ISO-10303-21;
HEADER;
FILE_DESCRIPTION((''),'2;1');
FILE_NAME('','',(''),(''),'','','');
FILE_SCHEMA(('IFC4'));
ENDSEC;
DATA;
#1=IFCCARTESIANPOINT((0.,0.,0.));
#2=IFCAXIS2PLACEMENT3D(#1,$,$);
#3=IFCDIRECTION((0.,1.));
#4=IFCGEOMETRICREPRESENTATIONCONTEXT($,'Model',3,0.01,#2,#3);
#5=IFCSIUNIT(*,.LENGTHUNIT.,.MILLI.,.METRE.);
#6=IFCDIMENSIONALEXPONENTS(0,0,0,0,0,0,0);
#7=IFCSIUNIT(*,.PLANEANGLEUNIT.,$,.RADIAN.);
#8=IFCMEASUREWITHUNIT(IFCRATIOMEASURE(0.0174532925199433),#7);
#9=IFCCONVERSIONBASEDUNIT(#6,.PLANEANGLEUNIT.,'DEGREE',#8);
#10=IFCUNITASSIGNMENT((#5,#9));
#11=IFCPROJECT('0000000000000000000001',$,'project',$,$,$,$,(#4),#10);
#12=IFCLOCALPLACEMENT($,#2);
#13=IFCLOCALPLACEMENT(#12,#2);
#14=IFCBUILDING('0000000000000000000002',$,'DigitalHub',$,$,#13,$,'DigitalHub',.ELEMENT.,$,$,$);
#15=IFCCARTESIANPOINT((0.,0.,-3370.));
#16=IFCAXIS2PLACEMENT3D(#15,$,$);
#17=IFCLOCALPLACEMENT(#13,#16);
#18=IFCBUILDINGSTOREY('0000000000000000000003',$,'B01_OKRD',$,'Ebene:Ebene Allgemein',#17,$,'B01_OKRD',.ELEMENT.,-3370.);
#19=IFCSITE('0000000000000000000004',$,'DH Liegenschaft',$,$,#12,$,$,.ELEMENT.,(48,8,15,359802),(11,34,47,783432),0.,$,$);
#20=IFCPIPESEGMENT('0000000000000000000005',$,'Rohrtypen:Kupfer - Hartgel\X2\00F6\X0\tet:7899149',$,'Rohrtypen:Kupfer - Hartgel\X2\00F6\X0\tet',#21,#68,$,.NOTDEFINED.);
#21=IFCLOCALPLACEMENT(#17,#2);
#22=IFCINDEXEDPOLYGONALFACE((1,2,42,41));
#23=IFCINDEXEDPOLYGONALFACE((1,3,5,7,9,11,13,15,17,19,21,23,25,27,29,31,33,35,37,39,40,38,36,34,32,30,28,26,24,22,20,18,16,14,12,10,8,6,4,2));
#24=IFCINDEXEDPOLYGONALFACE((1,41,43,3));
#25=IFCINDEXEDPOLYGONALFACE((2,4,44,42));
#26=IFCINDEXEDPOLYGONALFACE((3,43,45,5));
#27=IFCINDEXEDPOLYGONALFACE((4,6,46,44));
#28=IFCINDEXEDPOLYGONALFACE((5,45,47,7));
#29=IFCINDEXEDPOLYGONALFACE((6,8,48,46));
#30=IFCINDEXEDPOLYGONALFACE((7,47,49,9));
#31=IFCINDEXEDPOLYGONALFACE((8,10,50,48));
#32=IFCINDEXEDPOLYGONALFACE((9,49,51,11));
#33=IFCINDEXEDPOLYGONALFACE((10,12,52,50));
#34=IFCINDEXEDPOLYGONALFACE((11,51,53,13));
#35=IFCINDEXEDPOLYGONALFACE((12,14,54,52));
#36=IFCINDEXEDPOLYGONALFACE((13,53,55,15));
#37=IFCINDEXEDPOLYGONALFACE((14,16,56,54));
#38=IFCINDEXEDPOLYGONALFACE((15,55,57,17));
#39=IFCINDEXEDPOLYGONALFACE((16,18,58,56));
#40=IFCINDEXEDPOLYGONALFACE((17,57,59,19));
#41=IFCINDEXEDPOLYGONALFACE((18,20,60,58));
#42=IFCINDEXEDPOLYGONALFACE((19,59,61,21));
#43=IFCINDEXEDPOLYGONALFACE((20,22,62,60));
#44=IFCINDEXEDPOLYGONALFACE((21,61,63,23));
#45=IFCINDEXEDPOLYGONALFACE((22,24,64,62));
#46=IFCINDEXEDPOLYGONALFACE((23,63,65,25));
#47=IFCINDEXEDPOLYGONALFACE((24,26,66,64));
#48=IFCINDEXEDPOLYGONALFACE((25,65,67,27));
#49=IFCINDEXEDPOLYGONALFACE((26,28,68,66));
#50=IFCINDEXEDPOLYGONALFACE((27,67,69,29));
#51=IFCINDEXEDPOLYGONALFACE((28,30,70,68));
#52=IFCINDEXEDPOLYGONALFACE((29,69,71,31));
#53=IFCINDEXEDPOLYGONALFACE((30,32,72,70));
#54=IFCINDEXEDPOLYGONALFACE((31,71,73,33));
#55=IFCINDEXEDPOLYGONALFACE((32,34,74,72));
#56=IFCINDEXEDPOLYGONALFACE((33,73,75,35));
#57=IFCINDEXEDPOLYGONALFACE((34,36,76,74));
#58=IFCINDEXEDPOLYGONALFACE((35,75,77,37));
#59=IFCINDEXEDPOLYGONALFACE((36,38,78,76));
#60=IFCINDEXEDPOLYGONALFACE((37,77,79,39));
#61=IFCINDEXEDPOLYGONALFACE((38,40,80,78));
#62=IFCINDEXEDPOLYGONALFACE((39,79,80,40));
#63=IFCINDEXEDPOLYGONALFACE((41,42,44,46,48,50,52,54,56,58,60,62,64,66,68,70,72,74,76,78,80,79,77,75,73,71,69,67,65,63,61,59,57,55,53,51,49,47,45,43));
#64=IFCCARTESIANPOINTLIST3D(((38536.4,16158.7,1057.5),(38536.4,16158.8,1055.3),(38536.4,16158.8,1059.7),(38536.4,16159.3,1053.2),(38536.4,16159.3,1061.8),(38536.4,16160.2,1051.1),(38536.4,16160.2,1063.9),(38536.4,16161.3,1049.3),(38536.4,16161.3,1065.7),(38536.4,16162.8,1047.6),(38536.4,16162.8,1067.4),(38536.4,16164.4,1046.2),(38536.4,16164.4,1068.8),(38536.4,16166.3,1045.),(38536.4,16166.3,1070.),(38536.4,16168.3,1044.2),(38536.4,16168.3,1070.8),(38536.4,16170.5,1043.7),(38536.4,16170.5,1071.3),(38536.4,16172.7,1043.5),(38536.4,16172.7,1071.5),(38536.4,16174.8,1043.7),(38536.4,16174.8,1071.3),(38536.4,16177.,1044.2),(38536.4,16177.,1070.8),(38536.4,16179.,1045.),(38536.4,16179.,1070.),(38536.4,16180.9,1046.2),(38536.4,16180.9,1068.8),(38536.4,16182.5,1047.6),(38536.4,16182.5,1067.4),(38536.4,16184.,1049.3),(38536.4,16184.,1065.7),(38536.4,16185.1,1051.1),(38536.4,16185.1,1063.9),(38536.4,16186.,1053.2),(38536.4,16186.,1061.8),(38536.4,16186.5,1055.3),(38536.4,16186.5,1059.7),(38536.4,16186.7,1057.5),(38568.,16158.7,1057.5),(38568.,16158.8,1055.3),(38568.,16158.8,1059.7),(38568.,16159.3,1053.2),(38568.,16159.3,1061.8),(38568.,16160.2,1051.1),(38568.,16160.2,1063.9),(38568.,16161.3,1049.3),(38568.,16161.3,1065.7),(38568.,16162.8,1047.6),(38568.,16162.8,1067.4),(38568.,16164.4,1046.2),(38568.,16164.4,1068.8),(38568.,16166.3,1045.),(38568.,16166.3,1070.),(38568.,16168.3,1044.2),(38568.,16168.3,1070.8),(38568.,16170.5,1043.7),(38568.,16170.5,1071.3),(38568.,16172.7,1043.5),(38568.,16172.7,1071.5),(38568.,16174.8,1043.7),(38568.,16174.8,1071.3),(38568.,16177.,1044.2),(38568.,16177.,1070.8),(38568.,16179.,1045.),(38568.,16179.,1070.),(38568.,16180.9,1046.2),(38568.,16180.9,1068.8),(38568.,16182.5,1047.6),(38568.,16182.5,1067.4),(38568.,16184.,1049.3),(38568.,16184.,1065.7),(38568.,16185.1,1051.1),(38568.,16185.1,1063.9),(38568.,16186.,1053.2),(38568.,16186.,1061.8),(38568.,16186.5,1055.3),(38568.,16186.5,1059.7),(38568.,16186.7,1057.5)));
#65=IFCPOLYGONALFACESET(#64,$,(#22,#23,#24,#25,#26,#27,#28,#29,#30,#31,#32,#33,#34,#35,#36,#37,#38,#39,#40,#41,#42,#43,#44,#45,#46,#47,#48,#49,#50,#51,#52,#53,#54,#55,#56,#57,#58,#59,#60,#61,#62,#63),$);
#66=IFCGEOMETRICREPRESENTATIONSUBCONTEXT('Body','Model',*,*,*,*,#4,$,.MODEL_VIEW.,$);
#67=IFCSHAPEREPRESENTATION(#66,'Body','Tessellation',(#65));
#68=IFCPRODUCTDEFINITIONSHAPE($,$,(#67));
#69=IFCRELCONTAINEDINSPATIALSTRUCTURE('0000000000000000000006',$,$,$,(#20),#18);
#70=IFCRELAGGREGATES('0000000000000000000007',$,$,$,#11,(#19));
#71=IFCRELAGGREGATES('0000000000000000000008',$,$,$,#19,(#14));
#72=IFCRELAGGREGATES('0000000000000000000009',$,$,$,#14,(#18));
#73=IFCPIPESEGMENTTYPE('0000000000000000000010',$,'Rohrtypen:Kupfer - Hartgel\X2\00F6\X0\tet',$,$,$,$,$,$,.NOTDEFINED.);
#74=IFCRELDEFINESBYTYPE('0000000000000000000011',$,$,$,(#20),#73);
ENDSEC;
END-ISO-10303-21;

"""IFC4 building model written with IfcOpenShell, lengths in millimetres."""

from ifc_helpers import new_model, entity, si_unit, converted_unit, direction, frame, origin, place, context, subcontext, project, spatial, indexed_curve, outline, extrude, type_object, element, save


model = new_model("IFC4")

# Units and contexts
model_context = context("Model", 3, precision=0.01, world=origin(), true_north=direction((0.0, 1.0)))
body_context = subcontext(model_context, "Body", "Model", "MODEL_VIEW")
ifc_project = project(units=[si_unit("LENGTHUNIT", "METRE", prefix="MILLI"), converted_unit("PLANEANGLEUNIT", "DEGREE", entity("IfcRatioMeasure", 0.0174532925199433), si_unit("PLANEANGLEUNIT", "RADIAN"), dimensions=[0, 0, 0, 0, 0, 0, 0])], contexts=[model_context])

# Site, building, storey
site_placement = place(None, origin())
site = spatial("IfcSite", under=ifc_project, at=site_placement, Name="DH Liegenschaft", CompositionType="ELEMENT", RefLatitude=(48, 8, 15, 359802), RefLongitude=(11, 34, 47, 783432), RefElevation=0.0)
building_placement = place(site_placement, origin())
building = spatial("IfcBuilding", under=site, at=building_placement, Name="DigitalHub", LongName="DigitalHub", CompositionType="ELEMENT")
storey_placement = place(building_placement, frame((0.0, 0.0, -3370.0)))
storey = spatial("IfcBuildingStorey", under=building, at=storey_placement, Name="B01_OKRD", ObjectType="Ebene:Ebene Allgemein", LongName="B01_OKRD", CompositionType="ELEMENT", Elevation=-3370.0)

# Pipe segment
pipe_segment_type = type_object("IfcPipeSegmentType", Name="Rohrtypen:Kupfer - Hartgelötet", PredefinedType="NOTDEFINED")
pipe_segment_1_placement = place(storey_placement, frame((38536.4, 16157.1, 1041.9)))
element("IfcPipeSegment", 1, at=pipe_segment_1_placement, inside=storey, type_object=pipe_segment_type, Name="Rohrtypen:Kupfer - Hartgelötet:7899149", ObjectType="Rohrtypen:Kupfer - Hartgelötet", PredefinedType="NOTDEFINED", context=body_context, shape_type="SweptSolid", body=[
    extrude(outline(indexed_curve([(14.0, 0.0), (13.8, 2.2), (13.3, 4.3), (12.5, 6.4), (11.3, 8.2), (9.9, 9.9), (8.2, 11.3), (6.4, 12.5), (4.3, 13.3), (2.2, 13.8), (0.0, 14.0), (-2.2, 13.8), (-4.3, 13.3), (-6.4, 12.5), (-8.2, 11.3), (-9.9, 9.9), (-11.3, 8.2), (-12.5, 6.4), (-13.3, 4.3), (-13.8, 2.2), (-14.0, 0.0), (-13.8, -2.2), (-13.3, -4.3), (-12.5, -6.4), (-11.3, -8.2), (-9.9, -9.9), (-8.2, -11.3), (-6.4, -12.5), (-4.3, -13.3), (-2.2, -13.8), (0.0, -14.0), (2.2, -13.8), (4.3, -13.3), (6.4, -12.5), (8.2, -11.3), (9.9, -9.9), (11.3, -8.2), (12.5, -6.4), (13.3, -4.3), (13.8, -2.2), (14.0, 0.0)], self_intersect=False)), frame((0.0, 15.6, 15.6), z_axis=(1.0, 0.0, -0.000121), x_axis=(0.0, 1.0, 0.0)), (0.0, 0.0, 1.0), 31.6),
])

save(model, "model.ifc")
